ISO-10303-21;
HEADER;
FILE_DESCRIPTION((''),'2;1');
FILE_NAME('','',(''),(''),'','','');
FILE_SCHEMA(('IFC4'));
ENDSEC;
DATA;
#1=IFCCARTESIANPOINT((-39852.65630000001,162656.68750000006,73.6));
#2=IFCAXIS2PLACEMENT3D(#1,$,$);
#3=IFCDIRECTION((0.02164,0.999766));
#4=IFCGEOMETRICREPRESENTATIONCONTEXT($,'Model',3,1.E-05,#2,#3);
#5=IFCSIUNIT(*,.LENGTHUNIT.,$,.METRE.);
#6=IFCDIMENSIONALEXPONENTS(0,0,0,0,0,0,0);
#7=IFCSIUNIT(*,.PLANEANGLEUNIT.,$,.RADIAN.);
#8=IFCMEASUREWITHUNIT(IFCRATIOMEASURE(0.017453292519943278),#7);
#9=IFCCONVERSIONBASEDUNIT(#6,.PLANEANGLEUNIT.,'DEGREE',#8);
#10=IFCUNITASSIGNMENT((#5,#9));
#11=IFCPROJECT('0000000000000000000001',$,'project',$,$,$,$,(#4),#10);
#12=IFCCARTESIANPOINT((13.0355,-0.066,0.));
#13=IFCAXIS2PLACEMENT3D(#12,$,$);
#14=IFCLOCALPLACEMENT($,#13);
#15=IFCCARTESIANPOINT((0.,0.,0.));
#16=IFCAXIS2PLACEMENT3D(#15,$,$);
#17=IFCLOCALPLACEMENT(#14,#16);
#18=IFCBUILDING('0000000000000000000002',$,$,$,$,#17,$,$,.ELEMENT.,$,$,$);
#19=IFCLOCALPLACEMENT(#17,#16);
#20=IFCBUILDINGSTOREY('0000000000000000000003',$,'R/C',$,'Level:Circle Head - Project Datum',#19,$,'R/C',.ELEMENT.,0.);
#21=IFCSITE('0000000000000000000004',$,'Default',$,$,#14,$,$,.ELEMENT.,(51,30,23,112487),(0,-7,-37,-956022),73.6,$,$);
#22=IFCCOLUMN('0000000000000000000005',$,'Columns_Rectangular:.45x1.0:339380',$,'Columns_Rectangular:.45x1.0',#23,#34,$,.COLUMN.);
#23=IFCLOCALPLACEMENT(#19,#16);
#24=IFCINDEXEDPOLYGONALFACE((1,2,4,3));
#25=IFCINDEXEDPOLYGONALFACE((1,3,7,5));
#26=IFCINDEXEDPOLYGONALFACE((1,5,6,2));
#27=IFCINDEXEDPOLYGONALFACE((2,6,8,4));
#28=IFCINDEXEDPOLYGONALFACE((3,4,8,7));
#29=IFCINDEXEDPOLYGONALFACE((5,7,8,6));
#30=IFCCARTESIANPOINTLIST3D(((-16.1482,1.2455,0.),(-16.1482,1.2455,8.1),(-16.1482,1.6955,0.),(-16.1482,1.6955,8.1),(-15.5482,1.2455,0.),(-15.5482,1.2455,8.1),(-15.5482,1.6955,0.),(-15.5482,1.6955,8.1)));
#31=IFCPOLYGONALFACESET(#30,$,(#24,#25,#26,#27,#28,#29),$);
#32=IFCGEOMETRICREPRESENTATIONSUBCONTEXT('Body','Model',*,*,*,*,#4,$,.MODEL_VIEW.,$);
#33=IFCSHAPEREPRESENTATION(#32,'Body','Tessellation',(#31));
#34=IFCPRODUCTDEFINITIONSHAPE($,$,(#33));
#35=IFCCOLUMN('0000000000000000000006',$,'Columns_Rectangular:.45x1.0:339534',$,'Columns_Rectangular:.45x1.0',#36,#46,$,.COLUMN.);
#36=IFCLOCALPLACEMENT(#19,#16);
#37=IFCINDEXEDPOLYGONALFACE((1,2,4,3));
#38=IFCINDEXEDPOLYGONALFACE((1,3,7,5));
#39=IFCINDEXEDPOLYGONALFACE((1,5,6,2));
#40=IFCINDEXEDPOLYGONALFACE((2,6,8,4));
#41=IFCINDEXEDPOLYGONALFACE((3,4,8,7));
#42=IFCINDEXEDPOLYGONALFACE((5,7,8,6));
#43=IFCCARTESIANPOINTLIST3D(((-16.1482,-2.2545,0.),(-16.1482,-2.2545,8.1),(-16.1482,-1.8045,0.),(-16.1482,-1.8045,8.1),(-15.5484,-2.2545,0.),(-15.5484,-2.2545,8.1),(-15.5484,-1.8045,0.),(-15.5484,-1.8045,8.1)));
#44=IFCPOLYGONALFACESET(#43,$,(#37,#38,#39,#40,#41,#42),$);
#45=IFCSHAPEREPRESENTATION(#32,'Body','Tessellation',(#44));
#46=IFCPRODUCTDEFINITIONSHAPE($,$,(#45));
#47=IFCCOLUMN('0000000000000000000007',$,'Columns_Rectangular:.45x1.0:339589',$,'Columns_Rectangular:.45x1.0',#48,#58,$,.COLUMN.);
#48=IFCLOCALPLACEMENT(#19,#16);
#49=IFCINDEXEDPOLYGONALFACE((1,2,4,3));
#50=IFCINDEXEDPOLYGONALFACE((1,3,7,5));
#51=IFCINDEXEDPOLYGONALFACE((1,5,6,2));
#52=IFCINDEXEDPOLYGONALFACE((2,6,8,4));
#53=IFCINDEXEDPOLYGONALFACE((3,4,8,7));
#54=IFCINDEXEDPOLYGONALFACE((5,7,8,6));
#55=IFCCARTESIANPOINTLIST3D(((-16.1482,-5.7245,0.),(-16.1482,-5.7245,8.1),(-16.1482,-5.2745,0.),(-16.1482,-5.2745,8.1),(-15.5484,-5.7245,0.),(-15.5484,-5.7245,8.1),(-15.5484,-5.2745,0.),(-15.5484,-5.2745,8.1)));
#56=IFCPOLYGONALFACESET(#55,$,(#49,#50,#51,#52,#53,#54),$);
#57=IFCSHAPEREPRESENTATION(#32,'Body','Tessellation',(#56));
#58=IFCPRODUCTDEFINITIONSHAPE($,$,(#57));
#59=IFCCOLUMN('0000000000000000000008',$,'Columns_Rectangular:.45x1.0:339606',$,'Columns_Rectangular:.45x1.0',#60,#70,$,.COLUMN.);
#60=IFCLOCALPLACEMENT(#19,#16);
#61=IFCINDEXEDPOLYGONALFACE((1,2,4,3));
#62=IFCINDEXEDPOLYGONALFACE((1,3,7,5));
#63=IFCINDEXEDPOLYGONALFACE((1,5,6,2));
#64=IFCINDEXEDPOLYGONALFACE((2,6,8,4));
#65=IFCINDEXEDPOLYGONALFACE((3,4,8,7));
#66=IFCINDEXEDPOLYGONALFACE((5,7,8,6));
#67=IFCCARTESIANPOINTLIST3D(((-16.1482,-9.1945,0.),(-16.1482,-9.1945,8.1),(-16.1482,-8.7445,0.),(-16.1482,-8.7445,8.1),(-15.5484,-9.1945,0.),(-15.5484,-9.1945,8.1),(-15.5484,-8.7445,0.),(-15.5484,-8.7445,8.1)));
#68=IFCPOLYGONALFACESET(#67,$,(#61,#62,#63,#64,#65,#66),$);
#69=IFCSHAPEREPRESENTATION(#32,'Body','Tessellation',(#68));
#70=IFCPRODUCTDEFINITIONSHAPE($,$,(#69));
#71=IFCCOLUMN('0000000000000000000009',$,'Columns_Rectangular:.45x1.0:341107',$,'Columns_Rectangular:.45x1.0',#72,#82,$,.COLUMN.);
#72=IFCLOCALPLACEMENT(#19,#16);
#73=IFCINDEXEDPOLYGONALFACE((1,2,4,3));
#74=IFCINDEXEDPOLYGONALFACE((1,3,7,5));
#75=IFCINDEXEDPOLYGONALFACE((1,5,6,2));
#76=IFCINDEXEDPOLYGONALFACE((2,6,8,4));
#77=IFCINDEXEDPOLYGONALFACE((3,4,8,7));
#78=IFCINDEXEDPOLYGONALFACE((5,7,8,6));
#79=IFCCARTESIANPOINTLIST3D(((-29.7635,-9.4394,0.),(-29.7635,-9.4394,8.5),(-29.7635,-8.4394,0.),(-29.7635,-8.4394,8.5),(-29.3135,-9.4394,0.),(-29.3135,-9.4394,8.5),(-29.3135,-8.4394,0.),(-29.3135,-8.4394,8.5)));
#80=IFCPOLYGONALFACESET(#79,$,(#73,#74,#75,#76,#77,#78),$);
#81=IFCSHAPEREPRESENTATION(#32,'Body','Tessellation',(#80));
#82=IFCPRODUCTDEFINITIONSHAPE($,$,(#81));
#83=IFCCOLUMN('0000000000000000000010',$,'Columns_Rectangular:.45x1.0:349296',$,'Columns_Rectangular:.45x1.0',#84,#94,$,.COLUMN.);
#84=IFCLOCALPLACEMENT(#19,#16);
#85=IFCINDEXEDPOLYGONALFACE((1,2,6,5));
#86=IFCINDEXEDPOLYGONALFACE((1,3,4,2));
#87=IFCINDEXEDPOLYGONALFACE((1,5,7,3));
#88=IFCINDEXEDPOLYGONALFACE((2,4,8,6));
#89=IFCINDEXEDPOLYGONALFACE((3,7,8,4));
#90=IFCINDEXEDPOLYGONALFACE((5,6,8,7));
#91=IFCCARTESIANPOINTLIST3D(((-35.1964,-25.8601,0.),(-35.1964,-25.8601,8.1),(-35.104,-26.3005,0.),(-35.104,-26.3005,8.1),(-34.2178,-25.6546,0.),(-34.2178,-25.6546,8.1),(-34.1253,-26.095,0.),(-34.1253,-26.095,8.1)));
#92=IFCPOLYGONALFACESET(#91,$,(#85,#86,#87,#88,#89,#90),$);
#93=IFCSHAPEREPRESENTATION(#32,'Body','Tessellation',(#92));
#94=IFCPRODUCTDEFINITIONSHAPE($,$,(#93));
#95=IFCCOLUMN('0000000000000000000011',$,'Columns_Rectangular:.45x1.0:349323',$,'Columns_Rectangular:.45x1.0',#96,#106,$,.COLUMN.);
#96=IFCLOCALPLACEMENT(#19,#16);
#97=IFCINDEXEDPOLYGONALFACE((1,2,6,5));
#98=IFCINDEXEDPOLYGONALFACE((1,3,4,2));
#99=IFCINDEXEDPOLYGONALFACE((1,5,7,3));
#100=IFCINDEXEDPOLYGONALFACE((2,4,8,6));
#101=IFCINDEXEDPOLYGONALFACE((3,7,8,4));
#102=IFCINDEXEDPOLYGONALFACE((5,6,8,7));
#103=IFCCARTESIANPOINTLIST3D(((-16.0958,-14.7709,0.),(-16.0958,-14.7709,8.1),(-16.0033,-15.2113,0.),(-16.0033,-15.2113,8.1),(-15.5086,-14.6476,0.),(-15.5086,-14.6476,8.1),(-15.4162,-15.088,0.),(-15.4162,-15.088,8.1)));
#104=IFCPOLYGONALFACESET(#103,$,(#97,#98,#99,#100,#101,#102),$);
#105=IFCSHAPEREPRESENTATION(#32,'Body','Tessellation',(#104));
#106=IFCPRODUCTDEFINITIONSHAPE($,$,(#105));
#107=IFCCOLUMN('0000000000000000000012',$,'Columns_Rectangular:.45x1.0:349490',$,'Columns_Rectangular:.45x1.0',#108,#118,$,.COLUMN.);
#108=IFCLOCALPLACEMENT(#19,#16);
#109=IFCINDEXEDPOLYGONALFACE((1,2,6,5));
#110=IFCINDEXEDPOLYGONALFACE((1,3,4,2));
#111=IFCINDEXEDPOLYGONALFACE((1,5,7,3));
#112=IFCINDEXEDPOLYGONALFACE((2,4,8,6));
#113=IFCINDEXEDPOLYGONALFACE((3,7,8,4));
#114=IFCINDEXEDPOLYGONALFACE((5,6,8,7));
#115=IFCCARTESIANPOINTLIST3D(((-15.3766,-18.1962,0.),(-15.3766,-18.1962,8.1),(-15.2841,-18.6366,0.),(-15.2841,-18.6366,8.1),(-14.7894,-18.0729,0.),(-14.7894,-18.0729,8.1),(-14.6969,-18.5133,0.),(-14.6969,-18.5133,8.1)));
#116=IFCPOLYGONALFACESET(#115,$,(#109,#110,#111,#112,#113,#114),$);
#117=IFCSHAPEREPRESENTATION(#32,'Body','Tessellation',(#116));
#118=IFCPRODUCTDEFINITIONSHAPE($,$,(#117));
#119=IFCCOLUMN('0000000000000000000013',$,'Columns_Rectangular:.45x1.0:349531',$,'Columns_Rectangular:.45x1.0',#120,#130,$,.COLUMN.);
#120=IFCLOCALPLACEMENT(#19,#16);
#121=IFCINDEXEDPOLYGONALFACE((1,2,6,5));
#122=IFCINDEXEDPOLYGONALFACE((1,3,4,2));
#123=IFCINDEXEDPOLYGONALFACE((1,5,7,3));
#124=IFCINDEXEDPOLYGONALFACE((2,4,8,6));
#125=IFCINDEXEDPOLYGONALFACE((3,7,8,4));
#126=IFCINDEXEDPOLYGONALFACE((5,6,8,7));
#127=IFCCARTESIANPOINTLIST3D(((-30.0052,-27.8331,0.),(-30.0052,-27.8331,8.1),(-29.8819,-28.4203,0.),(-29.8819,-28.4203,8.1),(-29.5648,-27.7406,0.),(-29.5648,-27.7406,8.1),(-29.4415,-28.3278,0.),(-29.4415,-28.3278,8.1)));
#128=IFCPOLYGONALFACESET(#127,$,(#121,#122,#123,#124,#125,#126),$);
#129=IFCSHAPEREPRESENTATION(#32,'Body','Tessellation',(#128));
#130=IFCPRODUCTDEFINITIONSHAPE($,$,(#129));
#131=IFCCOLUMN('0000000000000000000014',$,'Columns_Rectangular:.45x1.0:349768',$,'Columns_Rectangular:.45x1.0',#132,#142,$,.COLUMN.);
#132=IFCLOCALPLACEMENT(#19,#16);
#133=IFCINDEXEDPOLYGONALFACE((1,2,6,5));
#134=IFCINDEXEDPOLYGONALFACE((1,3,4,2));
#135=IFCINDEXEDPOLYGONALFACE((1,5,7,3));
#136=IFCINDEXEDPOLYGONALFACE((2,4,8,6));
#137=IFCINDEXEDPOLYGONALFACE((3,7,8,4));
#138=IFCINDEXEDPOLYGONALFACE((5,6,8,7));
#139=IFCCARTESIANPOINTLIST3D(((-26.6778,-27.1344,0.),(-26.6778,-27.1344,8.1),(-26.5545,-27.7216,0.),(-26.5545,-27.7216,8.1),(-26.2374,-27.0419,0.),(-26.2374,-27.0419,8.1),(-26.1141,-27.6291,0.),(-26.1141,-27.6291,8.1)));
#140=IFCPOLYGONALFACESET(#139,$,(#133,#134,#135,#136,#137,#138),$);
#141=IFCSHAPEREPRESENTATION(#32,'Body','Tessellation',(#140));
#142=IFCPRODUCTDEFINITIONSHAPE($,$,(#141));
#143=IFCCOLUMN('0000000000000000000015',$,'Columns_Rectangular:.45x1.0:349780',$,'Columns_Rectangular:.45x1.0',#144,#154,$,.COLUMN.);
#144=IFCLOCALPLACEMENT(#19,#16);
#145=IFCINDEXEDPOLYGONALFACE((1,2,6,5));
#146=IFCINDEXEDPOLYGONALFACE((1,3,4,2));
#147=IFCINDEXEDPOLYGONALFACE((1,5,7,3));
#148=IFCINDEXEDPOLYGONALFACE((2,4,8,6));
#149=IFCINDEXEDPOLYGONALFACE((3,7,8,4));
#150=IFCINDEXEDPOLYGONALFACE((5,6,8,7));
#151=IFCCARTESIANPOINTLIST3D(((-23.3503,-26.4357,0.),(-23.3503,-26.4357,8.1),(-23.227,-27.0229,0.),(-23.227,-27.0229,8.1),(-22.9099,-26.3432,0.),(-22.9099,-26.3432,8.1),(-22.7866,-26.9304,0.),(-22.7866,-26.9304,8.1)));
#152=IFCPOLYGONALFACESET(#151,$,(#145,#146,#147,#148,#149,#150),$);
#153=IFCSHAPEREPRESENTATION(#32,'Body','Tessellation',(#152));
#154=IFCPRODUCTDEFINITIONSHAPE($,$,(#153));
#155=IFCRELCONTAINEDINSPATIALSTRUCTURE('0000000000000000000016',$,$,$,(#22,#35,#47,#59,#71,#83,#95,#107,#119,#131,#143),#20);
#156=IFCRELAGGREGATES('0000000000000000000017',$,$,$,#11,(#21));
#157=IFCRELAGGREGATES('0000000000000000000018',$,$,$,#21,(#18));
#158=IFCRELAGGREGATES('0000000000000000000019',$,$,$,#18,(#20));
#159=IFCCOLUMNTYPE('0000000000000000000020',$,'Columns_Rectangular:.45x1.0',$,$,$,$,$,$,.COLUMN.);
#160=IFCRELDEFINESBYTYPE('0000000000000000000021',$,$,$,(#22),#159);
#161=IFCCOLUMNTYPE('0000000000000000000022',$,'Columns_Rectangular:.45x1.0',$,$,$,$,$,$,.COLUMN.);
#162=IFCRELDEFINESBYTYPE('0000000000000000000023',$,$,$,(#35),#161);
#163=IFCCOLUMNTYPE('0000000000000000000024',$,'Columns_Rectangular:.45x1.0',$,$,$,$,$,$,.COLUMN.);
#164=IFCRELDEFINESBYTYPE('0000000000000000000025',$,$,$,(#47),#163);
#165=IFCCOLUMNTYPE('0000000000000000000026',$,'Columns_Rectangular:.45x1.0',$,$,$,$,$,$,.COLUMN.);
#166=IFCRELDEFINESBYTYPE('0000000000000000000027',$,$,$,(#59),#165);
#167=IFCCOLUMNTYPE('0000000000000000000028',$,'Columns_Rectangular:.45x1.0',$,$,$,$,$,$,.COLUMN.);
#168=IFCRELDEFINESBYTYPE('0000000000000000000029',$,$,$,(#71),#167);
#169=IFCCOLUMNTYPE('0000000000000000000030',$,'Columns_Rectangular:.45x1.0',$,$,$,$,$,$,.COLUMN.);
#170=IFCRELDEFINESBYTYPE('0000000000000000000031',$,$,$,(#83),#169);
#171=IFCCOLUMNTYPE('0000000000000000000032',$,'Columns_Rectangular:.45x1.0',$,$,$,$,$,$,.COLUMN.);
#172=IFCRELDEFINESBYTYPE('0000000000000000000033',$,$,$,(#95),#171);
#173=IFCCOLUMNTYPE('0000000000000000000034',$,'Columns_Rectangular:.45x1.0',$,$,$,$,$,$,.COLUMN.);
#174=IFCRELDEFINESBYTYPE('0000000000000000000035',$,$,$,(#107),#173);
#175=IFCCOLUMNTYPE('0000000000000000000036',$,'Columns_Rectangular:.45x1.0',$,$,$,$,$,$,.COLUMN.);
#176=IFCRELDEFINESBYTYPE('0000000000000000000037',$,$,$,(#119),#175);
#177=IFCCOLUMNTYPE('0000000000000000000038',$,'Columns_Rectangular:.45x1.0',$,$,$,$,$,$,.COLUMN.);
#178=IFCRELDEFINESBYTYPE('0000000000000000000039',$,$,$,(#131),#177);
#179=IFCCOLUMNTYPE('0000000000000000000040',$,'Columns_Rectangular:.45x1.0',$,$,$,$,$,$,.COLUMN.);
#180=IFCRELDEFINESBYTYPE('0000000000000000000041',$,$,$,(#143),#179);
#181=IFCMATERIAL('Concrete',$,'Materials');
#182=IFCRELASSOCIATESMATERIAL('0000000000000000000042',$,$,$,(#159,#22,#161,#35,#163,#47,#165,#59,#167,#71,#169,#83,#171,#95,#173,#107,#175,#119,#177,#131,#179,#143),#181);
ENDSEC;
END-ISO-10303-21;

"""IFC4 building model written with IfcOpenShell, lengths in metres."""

from ifc_helpers import new_model, entity, si_unit, converted_unit, direction, frame, origin, place, context, subcontext, project, spatial, indexed_curve, outline, extrude, source, transform, mapped, material, type_object, type_shapes, element, save


model = new_model("IFC4")

# Units and contexts
model_context = context("Model", 3, precision=1e-05, world=frame((-39852.65630000001, 162656.68750000006, 73.6)), true_north=direction((0.02164, 0.999766)))
body_context = subcontext(model_context, "Body", "Model", "MODEL_VIEW")
ifc_project = project(units=[si_unit("LENGTHUNIT", "METRE"), converted_unit("PLANEANGLEUNIT", "DEGREE", entity("IfcRatioMeasure", 0.017453292519943278), si_unit("PLANEANGLEUNIT", "RADIAN"), dimensions=[0, 0, 0, 0, 0, 0, 0])], contexts=[model_context])

# Site, building, storey
site_placement = place(None, frame((13.0355, -0.066, 0.0)))
site = spatial("IfcSite", under=ifc_project, at=site_placement, Name="Default", CompositionType="ELEMENT", RefLatitude=(51, 30, 23, 112487), RefLongitude=(0, -7, -37, -956022), RefElevation=73.6)
building_placement = place(site_placement, origin())
building = spatial("IfcBuilding", under=site, at=building_placement, CompositionType="ELEMENT")
storey_placement = place(building_placement, origin())
storey = spatial("IfcBuildingStorey", under=building, at=storey_placement, Name="R/C", ObjectType="Level:Circle Head - Project Datum", LongName="R/C", CompositionType="ELEMENT", Elevation=0.0)

# Columns
ifc_material = material(Name="Concrete", Category="Materials")
column_type_1 = type_object("IfcColumnType", Name="Columns_Rectangular:.45x1.0", PredefinedType="COLUMN", material=ifc_material)
shared_shape_1 = source(origin(), body_context, "Body", "SweptSolid", [
    extrude(outline(indexed_curve([(-0.225, -0.3), (0.225, -0.3), (0.225, 0.3), (-0.225, 0.3), (-0.225, -0.3)], self_intersect=False)), frame((-15.8482, 1.4705, 0.0), z_axis=(0.0, 0.0, 1.0), x_axis=(0.0, -1.0, 0.0)), (0.0, 0.0, 1.0), 8.1),
])
type_shapes(column_type_1, [shared_shape_1])
column_1_placement = place(storey_placement, origin())
element("IfcColumn", 1, at=column_1_placement, inside=storey, type_object=column_type_1, material=ifc_material, Name="Columns_Rectangular:.45x1.0:339380", ObjectType="Columns_Rectangular:.45x1.0", PredefinedType="COLUMN", context=body_context, shape_type="MappedRepresentation", body=[
    mapped(shared_shape_1, transform((0.0, 0.0, 0.0), scale=1.0)),
])
column_type_2 = type_object("IfcColumnType", Name="Columns_Rectangular:.45x1.0", PredefinedType="COLUMN", material=ifc_material)
shared_shape_2 = source(origin(), body_context, "Body", "SweptSolid", [
    extrude(outline(indexed_curve([(-0.225, -0.2999), (0.225, -0.2999), (0.225, 0.2999), (-0.225, 0.2999), (-0.225, -0.2999)], self_intersect=False)), frame((-15.8483, -2.0295, 0.0), z_axis=(0.0, 0.0, 1.0), x_axis=(0.0, -1.0, 0.0)), (0.0, 0.0, 1.0), 8.1),
])
type_shapes(column_type_2, [shared_shape_2])
column_2_placement = place(storey_placement, origin())
element("IfcColumn", 2, at=column_2_placement, inside=storey, type_object=column_type_2, material=ifc_material, Name="Columns_Rectangular:.45x1.0:339534", ObjectType="Columns_Rectangular:.45x1.0", PredefinedType="COLUMN", context=body_context, shape_type="MappedRepresentation", body=[
    mapped(shared_shape_2, transform((0.0, 0.0, 0.0), scale=1.0)),
])
column_type_3 = type_object("IfcColumnType", Name="Columns_Rectangular:.45x1.0", PredefinedType="COLUMN", material=ifc_material)
shared_shape_3 = source(origin(), body_context, "Body", "SweptSolid", [
    extrude(outline(indexed_curve([(-0.225, -0.2999), (0.225, -0.2999), (0.225, 0.2999), (-0.225, 0.2999), (-0.225, -0.2999)], self_intersect=False)), frame((-15.8483, -5.4995, 0.0), z_axis=(0.0, 0.0, 1.0), x_axis=(0.0, -1.0, 0.0)), (0.0, 0.0, 1.0), 8.1),
])
type_shapes(column_type_3, [shared_shape_3])
column_3_placement = place(storey_placement, origin())
element("IfcColumn", 3, at=column_3_placement, inside=storey, type_object=column_type_3, material=ifc_material, Name="Columns_Rectangular:.45x1.0:339589", ObjectType="Columns_Rectangular:.45x1.0", PredefinedType="COLUMN", context=body_context, shape_type="MappedRepresentation", body=[
    mapped(shared_shape_3, transform((0.0, 0.0, 0.0), scale=1.0)),
])
column_type_4 = type_object("IfcColumnType", Name="Columns_Rectangular:.45x1.0", PredefinedType="COLUMN", material=ifc_material)
shared_shape_4 = source(origin(), body_context, "Body", "SweptSolid", [
    extrude(outline(indexed_curve([(-0.225, -0.2999), (0.225, -0.2999), (0.225, 0.2999), (-0.225, 0.2999), (-0.225, -0.2999)], self_intersect=False)), frame((-15.8483, -8.9695, 0.0), z_axis=(0.0, 0.0, 1.0), x_axis=(0.0, -1.0, 0.0)), (0.0, 0.0, 1.0), 8.1),
])
type_shapes(column_type_4, [shared_shape_4])
column_4_placement = place(storey_placement, origin())
element("IfcColumn", 4, at=column_4_placement, inside=storey, type_object=column_type_4, material=ifc_material, Name="Columns_Rectangular:.45x1.0:339606", ObjectType="Columns_Rectangular:.45x1.0", PredefinedType="COLUMN", context=body_context, shape_type="MappedRepresentation", body=[
    mapped(shared_shape_4, transform((0.0, 0.0, 0.0), scale=1.0)),
])
column_type_5 = type_object("IfcColumnType", Name="Columns_Rectangular:.45x1.0", PredefinedType="COLUMN", material=ifc_material)
shared_shape_5 = source(origin(), body_context, "Body", "SweptSolid", [
    extrude(outline(indexed_curve([(-0.5, -0.225), (0.5, -0.225), (0.5, 0.225), (-0.5, 0.225), (-0.5, -0.225)], self_intersect=False)), frame((-29.5385, -8.9394, 0.0), z_axis=(0.0, 0.0, 1.0), x_axis=(0.0, -1.0, 0.0)), (0.0, 0.0, 1.0), 8.5),
])
type_shapes(column_type_5, [shared_shape_5])
column_5_placement = place(storey_placement, origin())
element("IfcColumn", 5, at=column_5_placement, inside=storey, type_object=column_type_5, material=ifc_material, Name="Columns_Rectangular:.45x1.0:341107", ObjectType="Columns_Rectangular:.45x1.0", PredefinedType="COLUMN", context=body_context, shape_type="MappedRepresentation", body=[
    mapped(shared_shape_5, transform((0.0, 0.0, 0.0), scale=1.0)),
])
column_type_6 = type_object("IfcColumnType", Name="Columns_Rectangular:.45x1.0", PredefinedType="COLUMN", material=ifc_material)
shared_shape_6 = source(origin(), body_context, "Body", "SweptSolid", [
    extrude(outline(indexed_curve([(-0.5, -0.225), (0.5, -0.225), (0.5, 0.225), (-0.5, 0.225), (-0.5, -0.225)], self_intersect=False)), frame((-34.6609, -25.9775, 0.0), z_axis=(0.0, 0.0, 1.0), x_axis=(-0.978657, -0.2055, 0.0)), (0.0, 0.0, 1.0), 8.1),
])
type_shapes(column_type_6, [shared_shape_6])
column_6_placement = place(storey_placement, origin())
element("IfcColumn", 6, at=column_6_placement, inside=storey, type_object=column_type_6, material=ifc_material, Name="Columns_Rectangular:.45x1.0:349296", ObjectType="Columns_Rectangular:.45x1.0", PredefinedType="COLUMN", context=body_context, shape_type="MappedRepresentation", body=[
    mapped(shared_shape_6, transform((0.0, 0.0, 0.0), scale=1.0)),
])
column_type_7 = type_object("IfcColumnType", Name="Columns_Rectangular:.45x1.0", PredefinedType="COLUMN", material=ifc_material)
shared_shape_7 = source(origin(), body_context, "Body", "SweptSolid", [
    extrude(outline(indexed_curve([(-0.3, -0.225), (0.3, -0.225), (0.3, 0.225), (-0.3, 0.225), (-0.3, -0.225)], self_intersect=False)), frame((-15.756, -14.9295, 0.0), z_axis=(0.0, 0.0, 1.0), x_axis=(-0.978657, -0.2055, 0.0)), (0.0, 0.0, 1.0), 8.1),
])
type_shapes(column_type_7, [shared_shape_7])
column_7_placement = place(storey_placement, origin())
element("IfcColumn", 7, at=column_7_placement, inside=storey, type_object=column_type_7, material=ifc_material, Name="Columns_Rectangular:.45x1.0:349323", ObjectType="Columns_Rectangular:.45x1.0", PredefinedType="COLUMN", context=body_context, shape_type="MappedRepresentation", body=[
    mapped(shared_shape_7, transform((0.0, 0.0, 0.0), scale=1.0)),
])
column_type_8 = type_object("IfcColumnType", Name="Columns_Rectangular:.45x1.0", PredefinedType="COLUMN", material=ifc_material)
shared_shape_8 = source(origin(), body_context, "Body", "SweptSolid", [
    extrude(outline(indexed_curve([(-0.3, -0.225), (0.3, -0.225), (0.3, 0.225), (-0.3, 0.225), (-0.3, -0.225)], self_intersect=False)), frame((-15.0367, -18.3548, 0.0), z_axis=(0.0, 0.0, 1.0), x_axis=(-0.978657, -0.2055, 0.0)), (0.0, 0.0, 1.0), 8.1),
])
type_shapes(column_type_8, [shared_shape_8])
column_8_placement = place(storey_placement, origin())
element("IfcColumn", 8, at=column_8_placement, inside=storey, type_object=column_type_8, material=ifc_material, Name="Columns_Rectangular:.45x1.0:349490", ObjectType="Columns_Rectangular:.45x1.0", PredefinedType="COLUMN", context=body_context, shape_type="MappedRepresentation", body=[
    mapped(shared_shape_8, transform((0.0, 0.0, 0.0), scale=1.0)),
])
column_type_9 = type_object("IfcColumnType", Name="Columns_Rectangular:.45x1.0", PredefinedType="COLUMN", material=ifc_material)
shared_shape_9 = source(origin(), body_context, "Body", "SweptSolid", [
    extrude(outline(indexed_curve([(-0.3, -0.225), (0.3, -0.225), (0.3, 0.225), (-0.3, 0.225), (-0.3, -0.225)], self_intersect=False)), frame((-29.7234, -28.0804, 0.0), z_axis=(0.0, 0.0, 1.0), x_axis=(-0.2055, 0.978657, 0.0)), (0.0, 0.0, 1.0), 8.1),
])
type_shapes(column_type_9, [shared_shape_9])
column_9_placement = place(storey_placement, origin())
element("IfcColumn", 9, at=column_9_placement, inside=storey, type_object=column_type_9, material=ifc_material, Name="Columns_Rectangular:.45x1.0:349531", ObjectType="Columns_Rectangular:.45x1.0", PredefinedType="COLUMN", context=body_context, shape_type="MappedRepresentation", body=[
    mapped(shared_shape_9, transform((0.0, 0.0, 0.0), scale=1.0)),
])
column_type_10 = type_object("IfcColumnType", Name="Columns_Rectangular:.45x1.0", PredefinedType="COLUMN", material=ifc_material)
shared_shape_10 = source(origin(), body_context, "Body", "SweptSolid", [
    extrude(outline(indexed_curve([(-0.3, -0.225), (0.3, -0.225), (0.3, 0.225), (-0.3, 0.225), (-0.3, -0.225)], self_intersect=False)), frame((-26.3959, -27.3817, 0.0), z_axis=(0.0, 0.0, 1.0), x_axis=(-0.2055, 0.978657, 0.0)), (0.0, 0.0, 1.0), 8.1),
])
type_shapes(column_type_10, [shared_shape_10])
column_10_placement = place(storey_placement, origin())
element("IfcColumn", 10, at=column_10_placement, inside=storey, type_object=column_type_10, material=ifc_material, Name="Columns_Rectangular:.45x1.0:349768", ObjectType="Columns_Rectangular:.45x1.0", PredefinedType="COLUMN", context=body_context, shape_type="MappedRepresentation", body=[
    mapped(shared_shape_10, transform((0.0, 0.0, 0.0), scale=1.0)),
])
column_type_11 = type_object("IfcColumnType", Name="Columns_Rectangular:.45x1.0", PredefinedType="COLUMN", material=ifc_material)
shared_shape_11 = source(origin(), body_context, "Body", "SweptSolid", [
    extrude(outline(indexed_curve([(-0.3, -0.225), (0.3, -0.225), (0.3, 0.225), (-0.3, 0.225), (-0.3, -0.225)], self_intersect=False)), frame((-23.0685, -26.6831, 0.0), z_axis=(0.0, 0.0, 1.0), x_axis=(-0.2055, 0.978657, 0.0)), (0.0, 0.0, 1.0), 8.1),
])
type_shapes(column_type_11, [shared_shape_11])
column_11_placement = place(storey_placement, origin())
element("IfcColumn", 11, at=column_11_placement, inside=storey, type_object=column_type_11, material=ifc_material, Name="Columns_Rectangular:.45x1.0:349780", ObjectType="Columns_Rectangular:.45x1.0", PredefinedType="COLUMN", context=body_context, shape_type="MappedRepresentation", body=[
    mapped(shared_shape_11, transform((0.0, 0.0, 0.0), scale=1.0)),
])

save(model, "model.ifc")
